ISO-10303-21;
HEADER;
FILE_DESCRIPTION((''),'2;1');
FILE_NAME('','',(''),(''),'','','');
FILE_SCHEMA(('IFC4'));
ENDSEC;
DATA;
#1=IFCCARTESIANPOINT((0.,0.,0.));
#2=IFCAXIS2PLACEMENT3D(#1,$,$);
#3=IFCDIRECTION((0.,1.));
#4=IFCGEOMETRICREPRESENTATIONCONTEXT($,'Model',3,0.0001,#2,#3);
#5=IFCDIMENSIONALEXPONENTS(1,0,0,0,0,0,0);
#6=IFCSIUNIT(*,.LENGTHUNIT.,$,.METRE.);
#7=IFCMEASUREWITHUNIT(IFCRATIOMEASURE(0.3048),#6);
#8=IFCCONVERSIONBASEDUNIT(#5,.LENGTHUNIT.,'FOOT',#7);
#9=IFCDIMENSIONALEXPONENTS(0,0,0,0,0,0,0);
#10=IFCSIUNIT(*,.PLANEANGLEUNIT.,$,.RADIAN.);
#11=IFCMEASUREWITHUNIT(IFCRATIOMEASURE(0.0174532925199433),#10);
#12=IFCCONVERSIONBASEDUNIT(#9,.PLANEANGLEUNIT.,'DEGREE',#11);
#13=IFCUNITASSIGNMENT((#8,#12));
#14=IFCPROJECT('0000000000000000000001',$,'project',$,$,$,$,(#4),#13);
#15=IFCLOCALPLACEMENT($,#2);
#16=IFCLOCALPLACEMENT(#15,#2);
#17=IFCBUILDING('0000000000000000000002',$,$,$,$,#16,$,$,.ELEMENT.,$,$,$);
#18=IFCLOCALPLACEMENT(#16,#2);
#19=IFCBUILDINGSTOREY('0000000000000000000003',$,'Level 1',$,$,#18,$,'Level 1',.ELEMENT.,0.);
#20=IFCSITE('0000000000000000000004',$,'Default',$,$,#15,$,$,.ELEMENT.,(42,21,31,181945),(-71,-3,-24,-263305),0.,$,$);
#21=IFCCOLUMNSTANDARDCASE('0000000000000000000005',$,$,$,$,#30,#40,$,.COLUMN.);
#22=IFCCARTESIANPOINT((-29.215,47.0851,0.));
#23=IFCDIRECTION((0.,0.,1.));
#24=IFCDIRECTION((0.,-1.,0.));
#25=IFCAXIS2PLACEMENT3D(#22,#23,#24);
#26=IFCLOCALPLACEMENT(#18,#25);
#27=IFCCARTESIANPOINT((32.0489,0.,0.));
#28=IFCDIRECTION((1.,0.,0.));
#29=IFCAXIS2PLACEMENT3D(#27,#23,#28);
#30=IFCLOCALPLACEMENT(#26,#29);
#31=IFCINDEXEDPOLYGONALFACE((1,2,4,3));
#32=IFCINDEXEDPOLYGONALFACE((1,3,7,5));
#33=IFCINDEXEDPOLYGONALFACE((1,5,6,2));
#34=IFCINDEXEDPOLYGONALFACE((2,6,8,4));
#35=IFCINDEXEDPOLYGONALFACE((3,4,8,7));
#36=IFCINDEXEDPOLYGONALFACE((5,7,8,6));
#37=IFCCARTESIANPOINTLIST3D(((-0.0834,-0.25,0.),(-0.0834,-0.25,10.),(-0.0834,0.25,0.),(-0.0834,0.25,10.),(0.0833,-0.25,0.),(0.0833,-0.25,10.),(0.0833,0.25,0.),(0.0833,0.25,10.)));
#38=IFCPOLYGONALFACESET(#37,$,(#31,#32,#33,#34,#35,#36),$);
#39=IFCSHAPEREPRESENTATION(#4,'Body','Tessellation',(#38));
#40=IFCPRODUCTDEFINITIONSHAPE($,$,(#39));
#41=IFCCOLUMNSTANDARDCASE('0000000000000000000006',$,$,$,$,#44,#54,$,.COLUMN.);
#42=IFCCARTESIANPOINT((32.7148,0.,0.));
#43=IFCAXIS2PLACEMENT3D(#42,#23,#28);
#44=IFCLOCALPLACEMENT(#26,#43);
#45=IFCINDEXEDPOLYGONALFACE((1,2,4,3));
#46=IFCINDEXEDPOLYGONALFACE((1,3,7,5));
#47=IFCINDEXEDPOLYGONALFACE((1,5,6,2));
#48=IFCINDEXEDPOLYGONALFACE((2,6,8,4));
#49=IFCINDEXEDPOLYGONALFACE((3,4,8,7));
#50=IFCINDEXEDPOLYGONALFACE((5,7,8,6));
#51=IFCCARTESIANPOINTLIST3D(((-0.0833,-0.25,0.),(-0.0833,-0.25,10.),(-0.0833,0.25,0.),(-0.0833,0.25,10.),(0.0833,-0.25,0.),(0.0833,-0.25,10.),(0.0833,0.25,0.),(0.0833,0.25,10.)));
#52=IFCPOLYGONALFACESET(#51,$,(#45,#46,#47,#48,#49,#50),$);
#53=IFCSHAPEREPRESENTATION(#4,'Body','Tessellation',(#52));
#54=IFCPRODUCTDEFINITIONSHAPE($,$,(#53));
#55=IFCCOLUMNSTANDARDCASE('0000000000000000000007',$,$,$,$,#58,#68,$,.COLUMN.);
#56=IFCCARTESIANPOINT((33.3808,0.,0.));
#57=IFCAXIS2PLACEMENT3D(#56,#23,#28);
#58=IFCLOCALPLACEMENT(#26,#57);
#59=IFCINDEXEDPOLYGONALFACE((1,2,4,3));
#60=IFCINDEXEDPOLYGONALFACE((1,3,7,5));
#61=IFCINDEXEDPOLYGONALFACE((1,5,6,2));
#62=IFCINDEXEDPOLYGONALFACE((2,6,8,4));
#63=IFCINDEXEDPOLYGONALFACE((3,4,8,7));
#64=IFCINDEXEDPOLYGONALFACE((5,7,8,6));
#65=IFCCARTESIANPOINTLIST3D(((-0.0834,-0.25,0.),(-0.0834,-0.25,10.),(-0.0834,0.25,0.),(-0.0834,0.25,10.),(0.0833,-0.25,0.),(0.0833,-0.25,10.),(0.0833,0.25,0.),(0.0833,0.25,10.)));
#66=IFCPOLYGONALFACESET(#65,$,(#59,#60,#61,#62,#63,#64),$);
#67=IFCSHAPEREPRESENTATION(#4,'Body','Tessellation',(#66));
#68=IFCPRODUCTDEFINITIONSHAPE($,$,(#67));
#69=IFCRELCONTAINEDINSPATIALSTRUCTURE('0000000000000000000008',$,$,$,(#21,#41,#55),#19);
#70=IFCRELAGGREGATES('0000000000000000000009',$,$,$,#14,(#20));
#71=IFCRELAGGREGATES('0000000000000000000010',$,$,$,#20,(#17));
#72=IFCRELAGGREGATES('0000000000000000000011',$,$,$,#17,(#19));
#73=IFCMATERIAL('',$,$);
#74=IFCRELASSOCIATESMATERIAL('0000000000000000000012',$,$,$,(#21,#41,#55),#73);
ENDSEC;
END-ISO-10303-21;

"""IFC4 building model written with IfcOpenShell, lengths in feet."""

from ifc_helpers import new_model, entity, si_unit, converted_unit, direction, frame, origin, place, context, project, spatial, rectangle, extrude, material, element, save


model = new_model("IFC4")

# Units and contexts
model_context = context("Model", 3, precision=0.0001, world=origin(), true_north=direction((0.0, 1.0)))
ifc_project = project(units=[converted_unit("LENGTHUNIT", "FOOT", entity("IfcRatioMeasure", 0.3048), si_unit("LENGTHUNIT", "METRE"), dimensions=[1, 0, 0, 0, 0, 0, 0]), converted_unit("PLANEANGLEUNIT", "DEGREE", entity("IfcRatioMeasure", 0.0174532925199433), si_unit("PLANEANGLEUNIT", "RADIAN"), dimensions=[0, 0, 0, 0, 0, 0, 0])], contexts=[model_context])

# Site, building, storey
site_placement = place(None, origin())
site = spatial("IfcSite", under=ifc_project, at=site_placement, Name="Default", CompositionType="ELEMENT", RefLatitude=(42, 21, 31, 181945), RefLongitude=(-71, -3, -24, -263305), RefElevation=0.0)
building_placement = place(site_placement, origin())
building = spatial("IfcBuilding", under=site, at=building_placement, CompositionType="ELEMENT")
storey_placement = place(building_placement, origin())
storey = spatial("IfcBuildingStorey", under=building, at=storey_placement, Name="Level 1", LongName="Level 1", CompositionType="ELEMENT", Elevation=0.0)

# Columns
ifc_material_1 = material(Name="")
placement_1 = place(storey_placement, frame((-29.215, 47.0851, 0.0), z_axis=(0.0, 0.0, 1.0), x_axis=(0.0, -1.0, 0.0)))
for number, where, z_axis, x_axis in (
    (1, (32.0489, 0.0, 0.0), (0.0, 0.0, 1.0), (1.0, 0.0, 0.0)),
    (2, (32.7148, 0.0, 0.0), (0.0, 0.0, 1.0), (1.0, 0.0, 0.0)),
    (3, (33.3808, 0.0, 0.0), (0.0, 0.0, 1.0), (1.0, 0.0, 0.0)),
):
    element("IfcColumnStandardCase", number, at=place(placement_1, frame(where, z_axis=z_axis, x_axis=x_axis)), inside=storey, material=ifc_material_1, PredefinedType="COLUMN", context=model_context, shape_type="SweptSolid", body=[
        extrude(rectangle(XDim=0.1667, YDim=0.5), origin(), (0.0, 0.0, 1.0), 10.0),
    ])

save(model, "model.ifc")
